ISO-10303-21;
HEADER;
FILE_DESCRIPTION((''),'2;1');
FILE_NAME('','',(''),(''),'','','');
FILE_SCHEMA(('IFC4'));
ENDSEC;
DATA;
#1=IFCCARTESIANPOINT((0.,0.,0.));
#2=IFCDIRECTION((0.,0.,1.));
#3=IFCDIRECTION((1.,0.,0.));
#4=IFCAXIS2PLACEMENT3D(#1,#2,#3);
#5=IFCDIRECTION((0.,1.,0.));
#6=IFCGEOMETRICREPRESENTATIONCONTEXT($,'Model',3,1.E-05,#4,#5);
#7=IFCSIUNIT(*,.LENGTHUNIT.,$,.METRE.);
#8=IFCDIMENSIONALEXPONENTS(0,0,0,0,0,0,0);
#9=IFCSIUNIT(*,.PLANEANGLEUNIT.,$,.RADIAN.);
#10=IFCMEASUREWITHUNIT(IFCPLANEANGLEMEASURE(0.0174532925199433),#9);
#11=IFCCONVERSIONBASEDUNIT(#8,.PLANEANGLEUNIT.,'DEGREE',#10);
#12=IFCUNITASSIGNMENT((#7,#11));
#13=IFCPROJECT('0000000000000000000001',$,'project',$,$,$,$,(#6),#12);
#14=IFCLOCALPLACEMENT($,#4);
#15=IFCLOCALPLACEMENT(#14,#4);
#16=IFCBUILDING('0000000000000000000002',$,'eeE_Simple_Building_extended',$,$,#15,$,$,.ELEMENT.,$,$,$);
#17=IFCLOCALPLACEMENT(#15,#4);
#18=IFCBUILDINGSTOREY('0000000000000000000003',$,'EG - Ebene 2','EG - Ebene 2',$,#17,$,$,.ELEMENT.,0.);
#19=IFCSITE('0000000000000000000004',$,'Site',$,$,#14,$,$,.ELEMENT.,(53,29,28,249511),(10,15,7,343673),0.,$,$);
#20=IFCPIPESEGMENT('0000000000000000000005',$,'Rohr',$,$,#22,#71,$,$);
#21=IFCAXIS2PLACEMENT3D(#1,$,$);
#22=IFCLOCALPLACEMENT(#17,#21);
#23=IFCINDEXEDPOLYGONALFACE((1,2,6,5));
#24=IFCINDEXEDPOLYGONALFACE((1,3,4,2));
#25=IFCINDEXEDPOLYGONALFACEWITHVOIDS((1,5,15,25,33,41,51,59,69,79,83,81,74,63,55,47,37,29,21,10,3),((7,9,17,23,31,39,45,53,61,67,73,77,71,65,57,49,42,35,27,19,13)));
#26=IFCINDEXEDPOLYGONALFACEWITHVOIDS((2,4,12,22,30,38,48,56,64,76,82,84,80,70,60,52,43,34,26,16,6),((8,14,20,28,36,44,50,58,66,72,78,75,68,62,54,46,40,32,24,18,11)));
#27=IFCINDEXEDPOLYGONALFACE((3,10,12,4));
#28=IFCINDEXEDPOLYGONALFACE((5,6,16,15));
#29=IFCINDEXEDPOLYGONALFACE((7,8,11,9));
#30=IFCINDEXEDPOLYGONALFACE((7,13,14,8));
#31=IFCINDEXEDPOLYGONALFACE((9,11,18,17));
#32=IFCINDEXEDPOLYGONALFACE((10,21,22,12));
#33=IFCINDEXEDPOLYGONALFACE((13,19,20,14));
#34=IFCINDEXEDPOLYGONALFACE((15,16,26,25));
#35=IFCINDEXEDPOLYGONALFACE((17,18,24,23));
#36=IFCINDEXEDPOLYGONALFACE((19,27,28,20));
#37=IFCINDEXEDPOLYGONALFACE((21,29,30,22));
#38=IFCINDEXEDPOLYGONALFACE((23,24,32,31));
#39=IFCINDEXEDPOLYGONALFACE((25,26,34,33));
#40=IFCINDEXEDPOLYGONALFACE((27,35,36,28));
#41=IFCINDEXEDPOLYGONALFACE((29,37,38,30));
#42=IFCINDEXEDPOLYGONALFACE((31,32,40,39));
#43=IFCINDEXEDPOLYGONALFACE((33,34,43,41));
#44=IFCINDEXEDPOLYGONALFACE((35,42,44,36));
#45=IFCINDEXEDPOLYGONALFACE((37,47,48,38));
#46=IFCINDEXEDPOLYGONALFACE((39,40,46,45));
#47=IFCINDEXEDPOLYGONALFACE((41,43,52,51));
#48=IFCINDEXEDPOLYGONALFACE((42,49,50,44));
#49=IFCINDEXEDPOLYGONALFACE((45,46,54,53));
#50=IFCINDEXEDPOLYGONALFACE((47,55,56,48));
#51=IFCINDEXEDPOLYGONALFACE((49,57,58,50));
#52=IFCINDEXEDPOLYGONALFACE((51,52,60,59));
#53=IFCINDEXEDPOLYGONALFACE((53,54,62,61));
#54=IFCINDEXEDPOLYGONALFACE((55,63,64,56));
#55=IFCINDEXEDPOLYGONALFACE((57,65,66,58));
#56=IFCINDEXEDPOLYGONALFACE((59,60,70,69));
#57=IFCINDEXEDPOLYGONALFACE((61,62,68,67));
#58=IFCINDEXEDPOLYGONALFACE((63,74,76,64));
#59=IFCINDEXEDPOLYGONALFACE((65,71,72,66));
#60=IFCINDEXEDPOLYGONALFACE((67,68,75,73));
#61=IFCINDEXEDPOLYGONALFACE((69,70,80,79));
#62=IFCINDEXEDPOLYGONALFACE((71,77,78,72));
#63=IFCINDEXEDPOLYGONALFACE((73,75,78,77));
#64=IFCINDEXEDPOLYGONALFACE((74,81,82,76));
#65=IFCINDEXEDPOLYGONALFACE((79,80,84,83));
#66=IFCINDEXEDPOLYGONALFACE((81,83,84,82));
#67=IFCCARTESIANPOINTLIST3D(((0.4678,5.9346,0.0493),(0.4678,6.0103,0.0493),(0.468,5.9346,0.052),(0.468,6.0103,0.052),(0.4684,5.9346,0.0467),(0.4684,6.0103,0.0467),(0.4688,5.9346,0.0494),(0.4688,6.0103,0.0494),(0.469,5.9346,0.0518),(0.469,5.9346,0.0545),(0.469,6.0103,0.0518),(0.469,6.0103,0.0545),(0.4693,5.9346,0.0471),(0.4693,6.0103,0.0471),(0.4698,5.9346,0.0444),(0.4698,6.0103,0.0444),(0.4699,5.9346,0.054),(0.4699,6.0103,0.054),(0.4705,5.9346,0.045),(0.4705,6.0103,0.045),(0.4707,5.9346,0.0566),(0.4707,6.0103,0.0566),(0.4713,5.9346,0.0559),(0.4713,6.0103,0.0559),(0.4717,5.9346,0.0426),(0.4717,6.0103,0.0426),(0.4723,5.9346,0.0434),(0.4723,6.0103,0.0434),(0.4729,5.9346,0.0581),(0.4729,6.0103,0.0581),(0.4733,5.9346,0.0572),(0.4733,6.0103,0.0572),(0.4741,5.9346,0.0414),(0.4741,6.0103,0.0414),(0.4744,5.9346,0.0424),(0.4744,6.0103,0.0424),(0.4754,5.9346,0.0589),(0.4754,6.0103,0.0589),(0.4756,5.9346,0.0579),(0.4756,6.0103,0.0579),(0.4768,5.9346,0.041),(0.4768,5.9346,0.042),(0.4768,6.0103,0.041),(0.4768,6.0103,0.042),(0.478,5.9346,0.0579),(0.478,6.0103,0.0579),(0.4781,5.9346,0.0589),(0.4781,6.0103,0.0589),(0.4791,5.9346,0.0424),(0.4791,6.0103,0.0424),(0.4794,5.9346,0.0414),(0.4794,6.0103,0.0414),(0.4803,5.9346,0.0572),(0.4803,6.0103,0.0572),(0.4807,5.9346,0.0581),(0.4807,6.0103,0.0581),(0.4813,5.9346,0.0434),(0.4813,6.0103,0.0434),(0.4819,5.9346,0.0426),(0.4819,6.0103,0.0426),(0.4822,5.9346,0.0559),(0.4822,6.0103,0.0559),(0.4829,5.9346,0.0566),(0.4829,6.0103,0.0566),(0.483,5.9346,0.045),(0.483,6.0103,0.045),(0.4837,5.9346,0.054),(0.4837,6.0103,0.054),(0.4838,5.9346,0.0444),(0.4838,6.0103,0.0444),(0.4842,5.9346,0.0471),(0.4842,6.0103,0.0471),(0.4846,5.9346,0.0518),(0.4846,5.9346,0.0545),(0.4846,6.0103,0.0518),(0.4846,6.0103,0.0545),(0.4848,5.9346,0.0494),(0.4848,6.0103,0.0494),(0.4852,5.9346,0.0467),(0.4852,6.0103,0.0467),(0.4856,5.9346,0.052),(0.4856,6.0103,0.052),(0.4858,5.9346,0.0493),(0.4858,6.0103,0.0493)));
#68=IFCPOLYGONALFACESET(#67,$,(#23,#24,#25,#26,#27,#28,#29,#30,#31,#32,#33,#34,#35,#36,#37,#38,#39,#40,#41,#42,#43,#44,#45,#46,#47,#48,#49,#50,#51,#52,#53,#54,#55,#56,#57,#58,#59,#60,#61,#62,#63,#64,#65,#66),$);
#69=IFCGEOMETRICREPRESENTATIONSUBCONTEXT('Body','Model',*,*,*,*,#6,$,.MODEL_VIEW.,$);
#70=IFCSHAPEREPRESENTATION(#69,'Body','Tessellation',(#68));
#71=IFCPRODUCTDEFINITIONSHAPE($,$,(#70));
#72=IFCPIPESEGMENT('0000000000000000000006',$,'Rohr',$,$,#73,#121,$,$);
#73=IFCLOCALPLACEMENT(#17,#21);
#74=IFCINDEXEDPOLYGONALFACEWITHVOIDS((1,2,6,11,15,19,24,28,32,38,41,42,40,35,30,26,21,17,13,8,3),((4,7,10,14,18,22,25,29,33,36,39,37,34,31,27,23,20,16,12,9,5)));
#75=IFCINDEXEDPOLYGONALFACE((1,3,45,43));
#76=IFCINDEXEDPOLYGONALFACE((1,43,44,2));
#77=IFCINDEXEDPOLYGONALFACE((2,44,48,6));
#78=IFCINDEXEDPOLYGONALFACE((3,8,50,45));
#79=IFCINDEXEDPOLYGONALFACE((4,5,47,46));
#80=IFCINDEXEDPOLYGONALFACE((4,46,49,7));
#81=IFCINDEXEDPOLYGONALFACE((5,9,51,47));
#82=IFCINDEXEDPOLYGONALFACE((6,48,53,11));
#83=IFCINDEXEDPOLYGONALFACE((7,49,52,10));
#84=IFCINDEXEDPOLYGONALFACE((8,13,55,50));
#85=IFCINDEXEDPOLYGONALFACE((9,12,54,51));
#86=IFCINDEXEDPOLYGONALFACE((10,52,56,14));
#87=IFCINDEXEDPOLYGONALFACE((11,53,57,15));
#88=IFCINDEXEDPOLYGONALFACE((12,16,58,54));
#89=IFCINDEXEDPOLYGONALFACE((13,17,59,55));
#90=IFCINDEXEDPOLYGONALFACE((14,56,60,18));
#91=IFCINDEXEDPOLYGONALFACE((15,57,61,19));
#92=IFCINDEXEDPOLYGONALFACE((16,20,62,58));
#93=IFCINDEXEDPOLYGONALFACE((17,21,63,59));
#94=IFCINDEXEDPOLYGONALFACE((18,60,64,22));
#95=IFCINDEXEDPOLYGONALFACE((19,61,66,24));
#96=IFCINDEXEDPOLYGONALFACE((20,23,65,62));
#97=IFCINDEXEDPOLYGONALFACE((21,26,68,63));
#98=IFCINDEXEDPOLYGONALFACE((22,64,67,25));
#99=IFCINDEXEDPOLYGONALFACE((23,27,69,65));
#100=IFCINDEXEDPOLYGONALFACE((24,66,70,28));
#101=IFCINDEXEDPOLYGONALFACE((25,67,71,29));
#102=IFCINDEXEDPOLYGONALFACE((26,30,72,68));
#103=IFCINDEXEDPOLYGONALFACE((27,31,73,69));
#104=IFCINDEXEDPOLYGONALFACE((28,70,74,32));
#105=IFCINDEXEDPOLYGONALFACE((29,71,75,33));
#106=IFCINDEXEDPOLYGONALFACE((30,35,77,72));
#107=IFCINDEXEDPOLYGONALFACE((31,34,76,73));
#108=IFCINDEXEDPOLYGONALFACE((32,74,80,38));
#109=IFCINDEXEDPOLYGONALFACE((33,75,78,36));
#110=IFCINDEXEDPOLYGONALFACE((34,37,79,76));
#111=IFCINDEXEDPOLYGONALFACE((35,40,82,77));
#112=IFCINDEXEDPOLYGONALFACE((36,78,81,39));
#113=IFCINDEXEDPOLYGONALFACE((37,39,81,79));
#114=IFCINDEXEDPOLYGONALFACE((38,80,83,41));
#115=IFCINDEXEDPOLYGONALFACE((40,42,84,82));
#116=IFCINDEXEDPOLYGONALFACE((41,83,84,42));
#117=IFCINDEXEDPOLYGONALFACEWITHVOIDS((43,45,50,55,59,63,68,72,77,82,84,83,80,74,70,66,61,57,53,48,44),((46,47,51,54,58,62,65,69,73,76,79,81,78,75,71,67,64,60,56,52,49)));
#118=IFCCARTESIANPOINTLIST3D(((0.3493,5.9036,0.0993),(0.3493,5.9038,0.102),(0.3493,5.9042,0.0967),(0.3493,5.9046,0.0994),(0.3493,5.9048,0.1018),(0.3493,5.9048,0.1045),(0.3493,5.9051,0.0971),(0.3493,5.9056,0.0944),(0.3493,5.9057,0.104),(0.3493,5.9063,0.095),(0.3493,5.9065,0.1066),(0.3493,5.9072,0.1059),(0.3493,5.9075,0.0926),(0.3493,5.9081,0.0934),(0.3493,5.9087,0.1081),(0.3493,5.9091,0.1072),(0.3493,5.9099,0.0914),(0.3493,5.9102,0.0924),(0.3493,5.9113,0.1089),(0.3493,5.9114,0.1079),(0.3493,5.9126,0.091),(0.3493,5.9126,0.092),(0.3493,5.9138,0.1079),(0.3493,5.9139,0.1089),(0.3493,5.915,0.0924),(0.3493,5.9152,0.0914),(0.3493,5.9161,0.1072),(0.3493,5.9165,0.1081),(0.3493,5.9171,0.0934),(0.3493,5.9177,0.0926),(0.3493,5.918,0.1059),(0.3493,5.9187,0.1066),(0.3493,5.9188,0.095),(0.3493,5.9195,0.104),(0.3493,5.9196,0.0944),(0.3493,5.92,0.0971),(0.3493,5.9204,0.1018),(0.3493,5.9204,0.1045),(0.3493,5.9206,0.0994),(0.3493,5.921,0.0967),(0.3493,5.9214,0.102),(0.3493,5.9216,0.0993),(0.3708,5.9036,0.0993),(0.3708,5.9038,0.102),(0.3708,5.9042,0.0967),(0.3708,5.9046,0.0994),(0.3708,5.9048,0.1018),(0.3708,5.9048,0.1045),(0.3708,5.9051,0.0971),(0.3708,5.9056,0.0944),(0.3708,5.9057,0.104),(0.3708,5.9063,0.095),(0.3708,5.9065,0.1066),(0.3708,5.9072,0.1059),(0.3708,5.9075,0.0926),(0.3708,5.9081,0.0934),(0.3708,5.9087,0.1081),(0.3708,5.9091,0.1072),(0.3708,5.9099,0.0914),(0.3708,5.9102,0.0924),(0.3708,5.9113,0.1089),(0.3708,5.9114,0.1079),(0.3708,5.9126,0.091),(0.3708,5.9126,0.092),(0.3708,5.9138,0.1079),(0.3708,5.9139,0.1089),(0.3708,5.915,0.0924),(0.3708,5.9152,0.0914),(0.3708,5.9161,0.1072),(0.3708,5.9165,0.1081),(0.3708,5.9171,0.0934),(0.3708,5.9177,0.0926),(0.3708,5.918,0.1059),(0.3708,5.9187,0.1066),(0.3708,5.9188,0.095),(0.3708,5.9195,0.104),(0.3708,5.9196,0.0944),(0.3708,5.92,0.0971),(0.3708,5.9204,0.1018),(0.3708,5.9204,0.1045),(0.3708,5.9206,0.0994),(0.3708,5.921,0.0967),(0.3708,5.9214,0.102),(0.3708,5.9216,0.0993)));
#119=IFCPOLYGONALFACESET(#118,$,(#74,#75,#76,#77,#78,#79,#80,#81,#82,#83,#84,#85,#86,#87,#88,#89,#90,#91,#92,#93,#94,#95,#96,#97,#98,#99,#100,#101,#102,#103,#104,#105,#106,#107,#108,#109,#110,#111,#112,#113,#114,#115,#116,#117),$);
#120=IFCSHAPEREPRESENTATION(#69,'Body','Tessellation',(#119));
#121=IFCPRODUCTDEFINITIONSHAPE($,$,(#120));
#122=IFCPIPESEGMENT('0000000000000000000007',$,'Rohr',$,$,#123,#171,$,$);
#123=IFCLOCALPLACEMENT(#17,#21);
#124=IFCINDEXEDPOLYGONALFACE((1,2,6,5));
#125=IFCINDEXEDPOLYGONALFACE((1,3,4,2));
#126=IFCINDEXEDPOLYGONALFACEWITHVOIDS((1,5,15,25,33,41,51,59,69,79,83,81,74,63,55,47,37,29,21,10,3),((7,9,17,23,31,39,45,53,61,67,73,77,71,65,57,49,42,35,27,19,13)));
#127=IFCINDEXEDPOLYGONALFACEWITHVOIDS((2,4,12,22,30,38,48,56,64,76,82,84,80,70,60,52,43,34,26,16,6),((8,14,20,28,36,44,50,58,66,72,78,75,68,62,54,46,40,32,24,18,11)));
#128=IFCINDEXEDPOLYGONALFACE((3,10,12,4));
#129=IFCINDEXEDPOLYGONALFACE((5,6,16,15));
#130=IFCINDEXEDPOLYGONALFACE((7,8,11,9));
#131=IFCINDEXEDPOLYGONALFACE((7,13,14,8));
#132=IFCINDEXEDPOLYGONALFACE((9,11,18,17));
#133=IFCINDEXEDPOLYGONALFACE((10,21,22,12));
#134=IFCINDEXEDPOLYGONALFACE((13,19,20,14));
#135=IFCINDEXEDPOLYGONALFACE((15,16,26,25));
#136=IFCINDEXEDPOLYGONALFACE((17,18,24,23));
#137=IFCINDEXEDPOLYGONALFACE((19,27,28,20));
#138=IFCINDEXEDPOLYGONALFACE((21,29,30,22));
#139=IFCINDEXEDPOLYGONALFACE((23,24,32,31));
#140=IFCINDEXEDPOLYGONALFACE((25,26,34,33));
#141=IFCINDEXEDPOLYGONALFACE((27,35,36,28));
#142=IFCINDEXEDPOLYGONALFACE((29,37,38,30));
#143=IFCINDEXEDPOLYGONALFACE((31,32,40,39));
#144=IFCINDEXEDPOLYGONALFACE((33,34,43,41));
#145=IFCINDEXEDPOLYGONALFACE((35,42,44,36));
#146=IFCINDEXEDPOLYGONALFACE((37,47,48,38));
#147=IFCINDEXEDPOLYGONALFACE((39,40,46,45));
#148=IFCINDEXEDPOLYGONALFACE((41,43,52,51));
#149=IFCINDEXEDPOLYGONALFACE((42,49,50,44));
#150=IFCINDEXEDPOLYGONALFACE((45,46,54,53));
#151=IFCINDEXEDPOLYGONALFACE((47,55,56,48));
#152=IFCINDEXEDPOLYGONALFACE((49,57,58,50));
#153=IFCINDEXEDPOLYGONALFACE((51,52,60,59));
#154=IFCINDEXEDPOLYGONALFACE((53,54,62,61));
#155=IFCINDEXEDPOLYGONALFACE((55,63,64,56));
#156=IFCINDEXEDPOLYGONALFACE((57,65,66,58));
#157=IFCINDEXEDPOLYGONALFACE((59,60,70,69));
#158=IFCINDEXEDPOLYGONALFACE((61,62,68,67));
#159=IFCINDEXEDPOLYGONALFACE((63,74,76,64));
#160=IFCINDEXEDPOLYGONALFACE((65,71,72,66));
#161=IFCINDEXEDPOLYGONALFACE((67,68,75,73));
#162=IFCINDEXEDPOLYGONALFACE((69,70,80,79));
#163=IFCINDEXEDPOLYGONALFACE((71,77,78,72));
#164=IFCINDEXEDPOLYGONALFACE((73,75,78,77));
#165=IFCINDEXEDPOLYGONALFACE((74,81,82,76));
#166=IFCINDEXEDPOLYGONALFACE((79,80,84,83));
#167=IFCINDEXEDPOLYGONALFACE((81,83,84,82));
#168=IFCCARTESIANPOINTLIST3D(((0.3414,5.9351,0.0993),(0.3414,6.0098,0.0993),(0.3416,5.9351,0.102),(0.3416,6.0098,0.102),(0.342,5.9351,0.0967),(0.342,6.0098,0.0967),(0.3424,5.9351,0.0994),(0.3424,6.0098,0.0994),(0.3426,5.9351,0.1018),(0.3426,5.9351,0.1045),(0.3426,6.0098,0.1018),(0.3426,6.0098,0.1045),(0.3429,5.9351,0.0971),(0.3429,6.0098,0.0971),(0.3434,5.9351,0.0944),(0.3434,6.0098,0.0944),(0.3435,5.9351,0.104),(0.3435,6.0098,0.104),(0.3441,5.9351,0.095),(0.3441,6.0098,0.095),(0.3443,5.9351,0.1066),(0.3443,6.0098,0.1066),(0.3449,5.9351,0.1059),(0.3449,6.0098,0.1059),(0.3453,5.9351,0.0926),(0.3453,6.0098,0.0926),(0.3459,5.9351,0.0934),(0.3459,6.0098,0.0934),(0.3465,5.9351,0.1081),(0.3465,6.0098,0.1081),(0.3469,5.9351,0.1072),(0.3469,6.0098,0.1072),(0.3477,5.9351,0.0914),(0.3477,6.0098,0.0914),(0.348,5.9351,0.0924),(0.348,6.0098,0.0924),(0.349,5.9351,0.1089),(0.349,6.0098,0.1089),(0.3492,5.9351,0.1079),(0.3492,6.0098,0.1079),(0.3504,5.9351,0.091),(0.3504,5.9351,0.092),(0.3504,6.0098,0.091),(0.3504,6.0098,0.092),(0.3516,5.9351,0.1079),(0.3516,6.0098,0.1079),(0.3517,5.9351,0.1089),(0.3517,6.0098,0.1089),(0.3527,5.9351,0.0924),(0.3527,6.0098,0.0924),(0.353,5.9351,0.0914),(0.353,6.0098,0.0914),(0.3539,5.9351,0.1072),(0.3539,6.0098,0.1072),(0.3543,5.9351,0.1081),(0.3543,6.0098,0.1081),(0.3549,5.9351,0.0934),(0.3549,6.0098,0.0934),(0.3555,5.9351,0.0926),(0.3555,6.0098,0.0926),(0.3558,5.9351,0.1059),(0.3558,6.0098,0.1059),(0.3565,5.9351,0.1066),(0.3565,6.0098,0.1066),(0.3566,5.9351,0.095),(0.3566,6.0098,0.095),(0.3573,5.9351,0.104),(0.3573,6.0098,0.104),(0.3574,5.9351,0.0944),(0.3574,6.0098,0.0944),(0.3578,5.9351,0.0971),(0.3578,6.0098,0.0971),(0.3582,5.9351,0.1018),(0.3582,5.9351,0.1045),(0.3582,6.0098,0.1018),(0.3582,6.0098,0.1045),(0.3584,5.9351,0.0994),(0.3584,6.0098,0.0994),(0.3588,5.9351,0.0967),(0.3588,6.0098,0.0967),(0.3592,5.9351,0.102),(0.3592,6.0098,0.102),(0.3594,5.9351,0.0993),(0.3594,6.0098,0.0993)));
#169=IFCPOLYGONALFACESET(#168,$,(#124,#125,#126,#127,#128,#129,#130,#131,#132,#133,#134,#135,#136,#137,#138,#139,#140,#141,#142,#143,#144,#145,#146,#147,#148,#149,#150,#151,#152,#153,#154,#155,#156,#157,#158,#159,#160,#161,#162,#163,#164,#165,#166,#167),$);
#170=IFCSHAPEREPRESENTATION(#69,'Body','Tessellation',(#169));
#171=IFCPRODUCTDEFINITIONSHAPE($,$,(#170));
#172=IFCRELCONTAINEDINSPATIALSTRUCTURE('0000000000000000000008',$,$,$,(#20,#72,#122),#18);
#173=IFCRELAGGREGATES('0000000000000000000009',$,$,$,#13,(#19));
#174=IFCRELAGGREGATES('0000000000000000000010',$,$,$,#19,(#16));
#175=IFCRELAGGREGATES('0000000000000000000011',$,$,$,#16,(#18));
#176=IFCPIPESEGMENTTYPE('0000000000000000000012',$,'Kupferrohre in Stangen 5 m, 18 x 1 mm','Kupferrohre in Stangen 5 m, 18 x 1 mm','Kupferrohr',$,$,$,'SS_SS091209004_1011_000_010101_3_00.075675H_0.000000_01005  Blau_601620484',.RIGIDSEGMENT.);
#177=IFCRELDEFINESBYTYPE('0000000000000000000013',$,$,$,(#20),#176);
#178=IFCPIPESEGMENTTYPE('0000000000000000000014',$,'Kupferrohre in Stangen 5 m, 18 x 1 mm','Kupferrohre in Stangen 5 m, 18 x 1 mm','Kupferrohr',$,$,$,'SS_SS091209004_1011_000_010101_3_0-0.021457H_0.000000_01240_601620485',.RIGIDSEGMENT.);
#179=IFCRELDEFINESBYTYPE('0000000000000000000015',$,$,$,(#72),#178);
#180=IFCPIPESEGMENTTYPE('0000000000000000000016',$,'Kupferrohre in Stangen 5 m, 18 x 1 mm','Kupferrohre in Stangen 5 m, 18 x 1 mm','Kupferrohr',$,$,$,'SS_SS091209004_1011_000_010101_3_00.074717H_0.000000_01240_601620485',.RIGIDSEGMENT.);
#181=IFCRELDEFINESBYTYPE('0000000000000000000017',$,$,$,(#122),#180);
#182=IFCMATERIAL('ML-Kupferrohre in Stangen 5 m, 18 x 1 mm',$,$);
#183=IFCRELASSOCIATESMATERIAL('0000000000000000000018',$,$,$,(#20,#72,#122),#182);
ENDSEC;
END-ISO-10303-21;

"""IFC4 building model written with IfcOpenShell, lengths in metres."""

from ifc_helpers import new_model, entity, si_unit, converted_unit, direction, frame, origin_with_axes, origin_2d_with_axis, place, context, subcontext, project, spatial, hollow_circle, extrude, material, type_object, element, save


model = new_model("IFC4")

# Units and contexts
model_context = context("Model", 3, precision=1e-05, world=origin_with_axes(), true_north=direction((0.0, 1.0, 0.0)))
body_context = subcontext(model_context, "Body", "Model", "MODEL_VIEW")
ifc_project = project(units=[si_unit("LENGTHUNIT", "METRE"), converted_unit("PLANEANGLEUNIT", "DEGREE", entity("IfcPlaneAngleMeasure", 0.0174532925199433), si_unit("PLANEANGLEUNIT", "RADIAN"), dimensions=[0, 0, 0, 0, 0, 0, 0])], contexts=[model_context])

# Site, building, storey
site_placement = place(None, origin_with_axes())
site = spatial("IfcSite", under=ifc_project, at=site_placement, Name="Site", CompositionType="ELEMENT", RefLatitude=(53, 29, 28, 249511), RefLongitude=(10, 15, 7, 343673), RefElevation=0.0)
building_placement = place(site_placement, origin_with_axes())
building = spatial("IfcBuilding", under=site, at=building_placement, Name="eeE_Simple_Building_extended", CompositionType="ELEMENT")
storey_placement = place(building_placement, origin_with_axes())
storey = spatial("IfcBuildingStorey", under=building, at=storey_placement, Name="EG - Ebene 2", Description="EG - Ebene 2", CompositionType="ELEMENT", Elevation=0.0)

# Pipe segments
ifc_material_1 = material(Name="ML-Kupferrohre in Stangen 5 m, 18 x 1 mm")
pipe_segment_type_1 = type_object("IfcPipeSegmentType", Name="Kupferrohre in Stangen 5 m, 18 x 1 mm", Description="Kupferrohre in Stangen 5 m, 18 x 1 mm", ApplicableOccurrence="Kupferrohr", ElementType="SS_SS091209004_1011_000_010101_3_00.075675H_0.000000_01005  Blau_601620484", PredefinedType="RIGIDSEGMENT")
pipe_segment_1_placement = place(storey_placement, frame((0.4768, 5.9346, 0.05), z_axis=(0.0, 0.0, 1.0), x_axis=(0.0, 1.0, 0.0)))
element("IfcPipeSegment", 1, at=pipe_segment_1_placement, inside=storey, type_object=pipe_segment_type_1, material=ifc_material_1, Name="Rohr", context=body_context, shape_type="SweptSolid", body=[
    extrude(hollow_circle(Radius=0.009, WallThickness=0.001, at=origin_2d_with_axis()), frame((0.0, 0.0, 0.0), z_axis=(1.0, 0.0, 0.0), x_axis=(0.0, 0.0, -1.0)), (0.0, 0.0, 1.0), 0.0757),
])
pipe_segment_type_2 = type_object("IfcPipeSegmentType", Name="Kupferrohre in Stangen 5 m, 18 x 1 mm", Description="Kupferrohre in Stangen 5 m, 18 x 1 mm", ApplicableOccurrence="Kupferrohr", ElementType="SS_SS091209004_1011_000_010101_3_0-0.021457H_0.000000_01240_601620485", PredefinedType="RIGIDSEGMENT")
pipe_segment_2_placement = place(storey_placement, frame((0.3493, 5.9126, 0.1), z_axis=(0.0, 0.0, 1.0), x_axis=(-1.0, 0.0, 0.0)))
element("IfcPipeSegment", 2, at=pipe_segment_2_placement, inside=storey, type_object=pipe_segment_type_2, material=ifc_material_1, Name="Rohr", context=body_context, shape_type="SweptSolid", body=[
    extrude(hollow_circle(Radius=0.009, WallThickness=0.001, at=origin_2d_with_axis()), frame((0.0, 0.0, 0.0), z_axis=(1.0, 0.0, 0.0), x_axis=(0.0, 0.0, -1.0)), (0.0, 0.0, -1.0), 0.0215),
])
pipe_segment_type_3 = type_object("IfcPipeSegmentType", Name="Kupferrohre in Stangen 5 m, 18 x 1 mm", Description="Kupferrohre in Stangen 5 m, 18 x 1 mm", ApplicableOccurrence="Kupferrohr", ElementType="SS_SS091209004_1011_000_010101_3_00.074717H_0.000000_01240_601620485", PredefinedType="RIGIDSEGMENT")
pipe_segment_3_placement = place(storey_placement, frame((0.3504, 5.9351, 0.1), z_axis=(0.0, 0.0, 1.0), x_axis=(0.0, 1.0, 0.0)))
element("IfcPipeSegment", 3, at=pipe_segment_3_placement, inside=storey, type_object=pipe_segment_type_3, material=ifc_material_1, Name="Rohr", context=body_context, shape_type="SweptSolid", body=[
    extrude(hollow_circle(Radius=0.009, WallThickness=0.001, at=origin_2d_with_axis()), frame((0.0, 0.0, 0.0), z_axis=(1.0, 0.0, 0.0), x_axis=(0.0, 0.0, -1.0)), (0.0, 0.0, 1.0), 0.0747),
])

save(model, "model.ifc")
